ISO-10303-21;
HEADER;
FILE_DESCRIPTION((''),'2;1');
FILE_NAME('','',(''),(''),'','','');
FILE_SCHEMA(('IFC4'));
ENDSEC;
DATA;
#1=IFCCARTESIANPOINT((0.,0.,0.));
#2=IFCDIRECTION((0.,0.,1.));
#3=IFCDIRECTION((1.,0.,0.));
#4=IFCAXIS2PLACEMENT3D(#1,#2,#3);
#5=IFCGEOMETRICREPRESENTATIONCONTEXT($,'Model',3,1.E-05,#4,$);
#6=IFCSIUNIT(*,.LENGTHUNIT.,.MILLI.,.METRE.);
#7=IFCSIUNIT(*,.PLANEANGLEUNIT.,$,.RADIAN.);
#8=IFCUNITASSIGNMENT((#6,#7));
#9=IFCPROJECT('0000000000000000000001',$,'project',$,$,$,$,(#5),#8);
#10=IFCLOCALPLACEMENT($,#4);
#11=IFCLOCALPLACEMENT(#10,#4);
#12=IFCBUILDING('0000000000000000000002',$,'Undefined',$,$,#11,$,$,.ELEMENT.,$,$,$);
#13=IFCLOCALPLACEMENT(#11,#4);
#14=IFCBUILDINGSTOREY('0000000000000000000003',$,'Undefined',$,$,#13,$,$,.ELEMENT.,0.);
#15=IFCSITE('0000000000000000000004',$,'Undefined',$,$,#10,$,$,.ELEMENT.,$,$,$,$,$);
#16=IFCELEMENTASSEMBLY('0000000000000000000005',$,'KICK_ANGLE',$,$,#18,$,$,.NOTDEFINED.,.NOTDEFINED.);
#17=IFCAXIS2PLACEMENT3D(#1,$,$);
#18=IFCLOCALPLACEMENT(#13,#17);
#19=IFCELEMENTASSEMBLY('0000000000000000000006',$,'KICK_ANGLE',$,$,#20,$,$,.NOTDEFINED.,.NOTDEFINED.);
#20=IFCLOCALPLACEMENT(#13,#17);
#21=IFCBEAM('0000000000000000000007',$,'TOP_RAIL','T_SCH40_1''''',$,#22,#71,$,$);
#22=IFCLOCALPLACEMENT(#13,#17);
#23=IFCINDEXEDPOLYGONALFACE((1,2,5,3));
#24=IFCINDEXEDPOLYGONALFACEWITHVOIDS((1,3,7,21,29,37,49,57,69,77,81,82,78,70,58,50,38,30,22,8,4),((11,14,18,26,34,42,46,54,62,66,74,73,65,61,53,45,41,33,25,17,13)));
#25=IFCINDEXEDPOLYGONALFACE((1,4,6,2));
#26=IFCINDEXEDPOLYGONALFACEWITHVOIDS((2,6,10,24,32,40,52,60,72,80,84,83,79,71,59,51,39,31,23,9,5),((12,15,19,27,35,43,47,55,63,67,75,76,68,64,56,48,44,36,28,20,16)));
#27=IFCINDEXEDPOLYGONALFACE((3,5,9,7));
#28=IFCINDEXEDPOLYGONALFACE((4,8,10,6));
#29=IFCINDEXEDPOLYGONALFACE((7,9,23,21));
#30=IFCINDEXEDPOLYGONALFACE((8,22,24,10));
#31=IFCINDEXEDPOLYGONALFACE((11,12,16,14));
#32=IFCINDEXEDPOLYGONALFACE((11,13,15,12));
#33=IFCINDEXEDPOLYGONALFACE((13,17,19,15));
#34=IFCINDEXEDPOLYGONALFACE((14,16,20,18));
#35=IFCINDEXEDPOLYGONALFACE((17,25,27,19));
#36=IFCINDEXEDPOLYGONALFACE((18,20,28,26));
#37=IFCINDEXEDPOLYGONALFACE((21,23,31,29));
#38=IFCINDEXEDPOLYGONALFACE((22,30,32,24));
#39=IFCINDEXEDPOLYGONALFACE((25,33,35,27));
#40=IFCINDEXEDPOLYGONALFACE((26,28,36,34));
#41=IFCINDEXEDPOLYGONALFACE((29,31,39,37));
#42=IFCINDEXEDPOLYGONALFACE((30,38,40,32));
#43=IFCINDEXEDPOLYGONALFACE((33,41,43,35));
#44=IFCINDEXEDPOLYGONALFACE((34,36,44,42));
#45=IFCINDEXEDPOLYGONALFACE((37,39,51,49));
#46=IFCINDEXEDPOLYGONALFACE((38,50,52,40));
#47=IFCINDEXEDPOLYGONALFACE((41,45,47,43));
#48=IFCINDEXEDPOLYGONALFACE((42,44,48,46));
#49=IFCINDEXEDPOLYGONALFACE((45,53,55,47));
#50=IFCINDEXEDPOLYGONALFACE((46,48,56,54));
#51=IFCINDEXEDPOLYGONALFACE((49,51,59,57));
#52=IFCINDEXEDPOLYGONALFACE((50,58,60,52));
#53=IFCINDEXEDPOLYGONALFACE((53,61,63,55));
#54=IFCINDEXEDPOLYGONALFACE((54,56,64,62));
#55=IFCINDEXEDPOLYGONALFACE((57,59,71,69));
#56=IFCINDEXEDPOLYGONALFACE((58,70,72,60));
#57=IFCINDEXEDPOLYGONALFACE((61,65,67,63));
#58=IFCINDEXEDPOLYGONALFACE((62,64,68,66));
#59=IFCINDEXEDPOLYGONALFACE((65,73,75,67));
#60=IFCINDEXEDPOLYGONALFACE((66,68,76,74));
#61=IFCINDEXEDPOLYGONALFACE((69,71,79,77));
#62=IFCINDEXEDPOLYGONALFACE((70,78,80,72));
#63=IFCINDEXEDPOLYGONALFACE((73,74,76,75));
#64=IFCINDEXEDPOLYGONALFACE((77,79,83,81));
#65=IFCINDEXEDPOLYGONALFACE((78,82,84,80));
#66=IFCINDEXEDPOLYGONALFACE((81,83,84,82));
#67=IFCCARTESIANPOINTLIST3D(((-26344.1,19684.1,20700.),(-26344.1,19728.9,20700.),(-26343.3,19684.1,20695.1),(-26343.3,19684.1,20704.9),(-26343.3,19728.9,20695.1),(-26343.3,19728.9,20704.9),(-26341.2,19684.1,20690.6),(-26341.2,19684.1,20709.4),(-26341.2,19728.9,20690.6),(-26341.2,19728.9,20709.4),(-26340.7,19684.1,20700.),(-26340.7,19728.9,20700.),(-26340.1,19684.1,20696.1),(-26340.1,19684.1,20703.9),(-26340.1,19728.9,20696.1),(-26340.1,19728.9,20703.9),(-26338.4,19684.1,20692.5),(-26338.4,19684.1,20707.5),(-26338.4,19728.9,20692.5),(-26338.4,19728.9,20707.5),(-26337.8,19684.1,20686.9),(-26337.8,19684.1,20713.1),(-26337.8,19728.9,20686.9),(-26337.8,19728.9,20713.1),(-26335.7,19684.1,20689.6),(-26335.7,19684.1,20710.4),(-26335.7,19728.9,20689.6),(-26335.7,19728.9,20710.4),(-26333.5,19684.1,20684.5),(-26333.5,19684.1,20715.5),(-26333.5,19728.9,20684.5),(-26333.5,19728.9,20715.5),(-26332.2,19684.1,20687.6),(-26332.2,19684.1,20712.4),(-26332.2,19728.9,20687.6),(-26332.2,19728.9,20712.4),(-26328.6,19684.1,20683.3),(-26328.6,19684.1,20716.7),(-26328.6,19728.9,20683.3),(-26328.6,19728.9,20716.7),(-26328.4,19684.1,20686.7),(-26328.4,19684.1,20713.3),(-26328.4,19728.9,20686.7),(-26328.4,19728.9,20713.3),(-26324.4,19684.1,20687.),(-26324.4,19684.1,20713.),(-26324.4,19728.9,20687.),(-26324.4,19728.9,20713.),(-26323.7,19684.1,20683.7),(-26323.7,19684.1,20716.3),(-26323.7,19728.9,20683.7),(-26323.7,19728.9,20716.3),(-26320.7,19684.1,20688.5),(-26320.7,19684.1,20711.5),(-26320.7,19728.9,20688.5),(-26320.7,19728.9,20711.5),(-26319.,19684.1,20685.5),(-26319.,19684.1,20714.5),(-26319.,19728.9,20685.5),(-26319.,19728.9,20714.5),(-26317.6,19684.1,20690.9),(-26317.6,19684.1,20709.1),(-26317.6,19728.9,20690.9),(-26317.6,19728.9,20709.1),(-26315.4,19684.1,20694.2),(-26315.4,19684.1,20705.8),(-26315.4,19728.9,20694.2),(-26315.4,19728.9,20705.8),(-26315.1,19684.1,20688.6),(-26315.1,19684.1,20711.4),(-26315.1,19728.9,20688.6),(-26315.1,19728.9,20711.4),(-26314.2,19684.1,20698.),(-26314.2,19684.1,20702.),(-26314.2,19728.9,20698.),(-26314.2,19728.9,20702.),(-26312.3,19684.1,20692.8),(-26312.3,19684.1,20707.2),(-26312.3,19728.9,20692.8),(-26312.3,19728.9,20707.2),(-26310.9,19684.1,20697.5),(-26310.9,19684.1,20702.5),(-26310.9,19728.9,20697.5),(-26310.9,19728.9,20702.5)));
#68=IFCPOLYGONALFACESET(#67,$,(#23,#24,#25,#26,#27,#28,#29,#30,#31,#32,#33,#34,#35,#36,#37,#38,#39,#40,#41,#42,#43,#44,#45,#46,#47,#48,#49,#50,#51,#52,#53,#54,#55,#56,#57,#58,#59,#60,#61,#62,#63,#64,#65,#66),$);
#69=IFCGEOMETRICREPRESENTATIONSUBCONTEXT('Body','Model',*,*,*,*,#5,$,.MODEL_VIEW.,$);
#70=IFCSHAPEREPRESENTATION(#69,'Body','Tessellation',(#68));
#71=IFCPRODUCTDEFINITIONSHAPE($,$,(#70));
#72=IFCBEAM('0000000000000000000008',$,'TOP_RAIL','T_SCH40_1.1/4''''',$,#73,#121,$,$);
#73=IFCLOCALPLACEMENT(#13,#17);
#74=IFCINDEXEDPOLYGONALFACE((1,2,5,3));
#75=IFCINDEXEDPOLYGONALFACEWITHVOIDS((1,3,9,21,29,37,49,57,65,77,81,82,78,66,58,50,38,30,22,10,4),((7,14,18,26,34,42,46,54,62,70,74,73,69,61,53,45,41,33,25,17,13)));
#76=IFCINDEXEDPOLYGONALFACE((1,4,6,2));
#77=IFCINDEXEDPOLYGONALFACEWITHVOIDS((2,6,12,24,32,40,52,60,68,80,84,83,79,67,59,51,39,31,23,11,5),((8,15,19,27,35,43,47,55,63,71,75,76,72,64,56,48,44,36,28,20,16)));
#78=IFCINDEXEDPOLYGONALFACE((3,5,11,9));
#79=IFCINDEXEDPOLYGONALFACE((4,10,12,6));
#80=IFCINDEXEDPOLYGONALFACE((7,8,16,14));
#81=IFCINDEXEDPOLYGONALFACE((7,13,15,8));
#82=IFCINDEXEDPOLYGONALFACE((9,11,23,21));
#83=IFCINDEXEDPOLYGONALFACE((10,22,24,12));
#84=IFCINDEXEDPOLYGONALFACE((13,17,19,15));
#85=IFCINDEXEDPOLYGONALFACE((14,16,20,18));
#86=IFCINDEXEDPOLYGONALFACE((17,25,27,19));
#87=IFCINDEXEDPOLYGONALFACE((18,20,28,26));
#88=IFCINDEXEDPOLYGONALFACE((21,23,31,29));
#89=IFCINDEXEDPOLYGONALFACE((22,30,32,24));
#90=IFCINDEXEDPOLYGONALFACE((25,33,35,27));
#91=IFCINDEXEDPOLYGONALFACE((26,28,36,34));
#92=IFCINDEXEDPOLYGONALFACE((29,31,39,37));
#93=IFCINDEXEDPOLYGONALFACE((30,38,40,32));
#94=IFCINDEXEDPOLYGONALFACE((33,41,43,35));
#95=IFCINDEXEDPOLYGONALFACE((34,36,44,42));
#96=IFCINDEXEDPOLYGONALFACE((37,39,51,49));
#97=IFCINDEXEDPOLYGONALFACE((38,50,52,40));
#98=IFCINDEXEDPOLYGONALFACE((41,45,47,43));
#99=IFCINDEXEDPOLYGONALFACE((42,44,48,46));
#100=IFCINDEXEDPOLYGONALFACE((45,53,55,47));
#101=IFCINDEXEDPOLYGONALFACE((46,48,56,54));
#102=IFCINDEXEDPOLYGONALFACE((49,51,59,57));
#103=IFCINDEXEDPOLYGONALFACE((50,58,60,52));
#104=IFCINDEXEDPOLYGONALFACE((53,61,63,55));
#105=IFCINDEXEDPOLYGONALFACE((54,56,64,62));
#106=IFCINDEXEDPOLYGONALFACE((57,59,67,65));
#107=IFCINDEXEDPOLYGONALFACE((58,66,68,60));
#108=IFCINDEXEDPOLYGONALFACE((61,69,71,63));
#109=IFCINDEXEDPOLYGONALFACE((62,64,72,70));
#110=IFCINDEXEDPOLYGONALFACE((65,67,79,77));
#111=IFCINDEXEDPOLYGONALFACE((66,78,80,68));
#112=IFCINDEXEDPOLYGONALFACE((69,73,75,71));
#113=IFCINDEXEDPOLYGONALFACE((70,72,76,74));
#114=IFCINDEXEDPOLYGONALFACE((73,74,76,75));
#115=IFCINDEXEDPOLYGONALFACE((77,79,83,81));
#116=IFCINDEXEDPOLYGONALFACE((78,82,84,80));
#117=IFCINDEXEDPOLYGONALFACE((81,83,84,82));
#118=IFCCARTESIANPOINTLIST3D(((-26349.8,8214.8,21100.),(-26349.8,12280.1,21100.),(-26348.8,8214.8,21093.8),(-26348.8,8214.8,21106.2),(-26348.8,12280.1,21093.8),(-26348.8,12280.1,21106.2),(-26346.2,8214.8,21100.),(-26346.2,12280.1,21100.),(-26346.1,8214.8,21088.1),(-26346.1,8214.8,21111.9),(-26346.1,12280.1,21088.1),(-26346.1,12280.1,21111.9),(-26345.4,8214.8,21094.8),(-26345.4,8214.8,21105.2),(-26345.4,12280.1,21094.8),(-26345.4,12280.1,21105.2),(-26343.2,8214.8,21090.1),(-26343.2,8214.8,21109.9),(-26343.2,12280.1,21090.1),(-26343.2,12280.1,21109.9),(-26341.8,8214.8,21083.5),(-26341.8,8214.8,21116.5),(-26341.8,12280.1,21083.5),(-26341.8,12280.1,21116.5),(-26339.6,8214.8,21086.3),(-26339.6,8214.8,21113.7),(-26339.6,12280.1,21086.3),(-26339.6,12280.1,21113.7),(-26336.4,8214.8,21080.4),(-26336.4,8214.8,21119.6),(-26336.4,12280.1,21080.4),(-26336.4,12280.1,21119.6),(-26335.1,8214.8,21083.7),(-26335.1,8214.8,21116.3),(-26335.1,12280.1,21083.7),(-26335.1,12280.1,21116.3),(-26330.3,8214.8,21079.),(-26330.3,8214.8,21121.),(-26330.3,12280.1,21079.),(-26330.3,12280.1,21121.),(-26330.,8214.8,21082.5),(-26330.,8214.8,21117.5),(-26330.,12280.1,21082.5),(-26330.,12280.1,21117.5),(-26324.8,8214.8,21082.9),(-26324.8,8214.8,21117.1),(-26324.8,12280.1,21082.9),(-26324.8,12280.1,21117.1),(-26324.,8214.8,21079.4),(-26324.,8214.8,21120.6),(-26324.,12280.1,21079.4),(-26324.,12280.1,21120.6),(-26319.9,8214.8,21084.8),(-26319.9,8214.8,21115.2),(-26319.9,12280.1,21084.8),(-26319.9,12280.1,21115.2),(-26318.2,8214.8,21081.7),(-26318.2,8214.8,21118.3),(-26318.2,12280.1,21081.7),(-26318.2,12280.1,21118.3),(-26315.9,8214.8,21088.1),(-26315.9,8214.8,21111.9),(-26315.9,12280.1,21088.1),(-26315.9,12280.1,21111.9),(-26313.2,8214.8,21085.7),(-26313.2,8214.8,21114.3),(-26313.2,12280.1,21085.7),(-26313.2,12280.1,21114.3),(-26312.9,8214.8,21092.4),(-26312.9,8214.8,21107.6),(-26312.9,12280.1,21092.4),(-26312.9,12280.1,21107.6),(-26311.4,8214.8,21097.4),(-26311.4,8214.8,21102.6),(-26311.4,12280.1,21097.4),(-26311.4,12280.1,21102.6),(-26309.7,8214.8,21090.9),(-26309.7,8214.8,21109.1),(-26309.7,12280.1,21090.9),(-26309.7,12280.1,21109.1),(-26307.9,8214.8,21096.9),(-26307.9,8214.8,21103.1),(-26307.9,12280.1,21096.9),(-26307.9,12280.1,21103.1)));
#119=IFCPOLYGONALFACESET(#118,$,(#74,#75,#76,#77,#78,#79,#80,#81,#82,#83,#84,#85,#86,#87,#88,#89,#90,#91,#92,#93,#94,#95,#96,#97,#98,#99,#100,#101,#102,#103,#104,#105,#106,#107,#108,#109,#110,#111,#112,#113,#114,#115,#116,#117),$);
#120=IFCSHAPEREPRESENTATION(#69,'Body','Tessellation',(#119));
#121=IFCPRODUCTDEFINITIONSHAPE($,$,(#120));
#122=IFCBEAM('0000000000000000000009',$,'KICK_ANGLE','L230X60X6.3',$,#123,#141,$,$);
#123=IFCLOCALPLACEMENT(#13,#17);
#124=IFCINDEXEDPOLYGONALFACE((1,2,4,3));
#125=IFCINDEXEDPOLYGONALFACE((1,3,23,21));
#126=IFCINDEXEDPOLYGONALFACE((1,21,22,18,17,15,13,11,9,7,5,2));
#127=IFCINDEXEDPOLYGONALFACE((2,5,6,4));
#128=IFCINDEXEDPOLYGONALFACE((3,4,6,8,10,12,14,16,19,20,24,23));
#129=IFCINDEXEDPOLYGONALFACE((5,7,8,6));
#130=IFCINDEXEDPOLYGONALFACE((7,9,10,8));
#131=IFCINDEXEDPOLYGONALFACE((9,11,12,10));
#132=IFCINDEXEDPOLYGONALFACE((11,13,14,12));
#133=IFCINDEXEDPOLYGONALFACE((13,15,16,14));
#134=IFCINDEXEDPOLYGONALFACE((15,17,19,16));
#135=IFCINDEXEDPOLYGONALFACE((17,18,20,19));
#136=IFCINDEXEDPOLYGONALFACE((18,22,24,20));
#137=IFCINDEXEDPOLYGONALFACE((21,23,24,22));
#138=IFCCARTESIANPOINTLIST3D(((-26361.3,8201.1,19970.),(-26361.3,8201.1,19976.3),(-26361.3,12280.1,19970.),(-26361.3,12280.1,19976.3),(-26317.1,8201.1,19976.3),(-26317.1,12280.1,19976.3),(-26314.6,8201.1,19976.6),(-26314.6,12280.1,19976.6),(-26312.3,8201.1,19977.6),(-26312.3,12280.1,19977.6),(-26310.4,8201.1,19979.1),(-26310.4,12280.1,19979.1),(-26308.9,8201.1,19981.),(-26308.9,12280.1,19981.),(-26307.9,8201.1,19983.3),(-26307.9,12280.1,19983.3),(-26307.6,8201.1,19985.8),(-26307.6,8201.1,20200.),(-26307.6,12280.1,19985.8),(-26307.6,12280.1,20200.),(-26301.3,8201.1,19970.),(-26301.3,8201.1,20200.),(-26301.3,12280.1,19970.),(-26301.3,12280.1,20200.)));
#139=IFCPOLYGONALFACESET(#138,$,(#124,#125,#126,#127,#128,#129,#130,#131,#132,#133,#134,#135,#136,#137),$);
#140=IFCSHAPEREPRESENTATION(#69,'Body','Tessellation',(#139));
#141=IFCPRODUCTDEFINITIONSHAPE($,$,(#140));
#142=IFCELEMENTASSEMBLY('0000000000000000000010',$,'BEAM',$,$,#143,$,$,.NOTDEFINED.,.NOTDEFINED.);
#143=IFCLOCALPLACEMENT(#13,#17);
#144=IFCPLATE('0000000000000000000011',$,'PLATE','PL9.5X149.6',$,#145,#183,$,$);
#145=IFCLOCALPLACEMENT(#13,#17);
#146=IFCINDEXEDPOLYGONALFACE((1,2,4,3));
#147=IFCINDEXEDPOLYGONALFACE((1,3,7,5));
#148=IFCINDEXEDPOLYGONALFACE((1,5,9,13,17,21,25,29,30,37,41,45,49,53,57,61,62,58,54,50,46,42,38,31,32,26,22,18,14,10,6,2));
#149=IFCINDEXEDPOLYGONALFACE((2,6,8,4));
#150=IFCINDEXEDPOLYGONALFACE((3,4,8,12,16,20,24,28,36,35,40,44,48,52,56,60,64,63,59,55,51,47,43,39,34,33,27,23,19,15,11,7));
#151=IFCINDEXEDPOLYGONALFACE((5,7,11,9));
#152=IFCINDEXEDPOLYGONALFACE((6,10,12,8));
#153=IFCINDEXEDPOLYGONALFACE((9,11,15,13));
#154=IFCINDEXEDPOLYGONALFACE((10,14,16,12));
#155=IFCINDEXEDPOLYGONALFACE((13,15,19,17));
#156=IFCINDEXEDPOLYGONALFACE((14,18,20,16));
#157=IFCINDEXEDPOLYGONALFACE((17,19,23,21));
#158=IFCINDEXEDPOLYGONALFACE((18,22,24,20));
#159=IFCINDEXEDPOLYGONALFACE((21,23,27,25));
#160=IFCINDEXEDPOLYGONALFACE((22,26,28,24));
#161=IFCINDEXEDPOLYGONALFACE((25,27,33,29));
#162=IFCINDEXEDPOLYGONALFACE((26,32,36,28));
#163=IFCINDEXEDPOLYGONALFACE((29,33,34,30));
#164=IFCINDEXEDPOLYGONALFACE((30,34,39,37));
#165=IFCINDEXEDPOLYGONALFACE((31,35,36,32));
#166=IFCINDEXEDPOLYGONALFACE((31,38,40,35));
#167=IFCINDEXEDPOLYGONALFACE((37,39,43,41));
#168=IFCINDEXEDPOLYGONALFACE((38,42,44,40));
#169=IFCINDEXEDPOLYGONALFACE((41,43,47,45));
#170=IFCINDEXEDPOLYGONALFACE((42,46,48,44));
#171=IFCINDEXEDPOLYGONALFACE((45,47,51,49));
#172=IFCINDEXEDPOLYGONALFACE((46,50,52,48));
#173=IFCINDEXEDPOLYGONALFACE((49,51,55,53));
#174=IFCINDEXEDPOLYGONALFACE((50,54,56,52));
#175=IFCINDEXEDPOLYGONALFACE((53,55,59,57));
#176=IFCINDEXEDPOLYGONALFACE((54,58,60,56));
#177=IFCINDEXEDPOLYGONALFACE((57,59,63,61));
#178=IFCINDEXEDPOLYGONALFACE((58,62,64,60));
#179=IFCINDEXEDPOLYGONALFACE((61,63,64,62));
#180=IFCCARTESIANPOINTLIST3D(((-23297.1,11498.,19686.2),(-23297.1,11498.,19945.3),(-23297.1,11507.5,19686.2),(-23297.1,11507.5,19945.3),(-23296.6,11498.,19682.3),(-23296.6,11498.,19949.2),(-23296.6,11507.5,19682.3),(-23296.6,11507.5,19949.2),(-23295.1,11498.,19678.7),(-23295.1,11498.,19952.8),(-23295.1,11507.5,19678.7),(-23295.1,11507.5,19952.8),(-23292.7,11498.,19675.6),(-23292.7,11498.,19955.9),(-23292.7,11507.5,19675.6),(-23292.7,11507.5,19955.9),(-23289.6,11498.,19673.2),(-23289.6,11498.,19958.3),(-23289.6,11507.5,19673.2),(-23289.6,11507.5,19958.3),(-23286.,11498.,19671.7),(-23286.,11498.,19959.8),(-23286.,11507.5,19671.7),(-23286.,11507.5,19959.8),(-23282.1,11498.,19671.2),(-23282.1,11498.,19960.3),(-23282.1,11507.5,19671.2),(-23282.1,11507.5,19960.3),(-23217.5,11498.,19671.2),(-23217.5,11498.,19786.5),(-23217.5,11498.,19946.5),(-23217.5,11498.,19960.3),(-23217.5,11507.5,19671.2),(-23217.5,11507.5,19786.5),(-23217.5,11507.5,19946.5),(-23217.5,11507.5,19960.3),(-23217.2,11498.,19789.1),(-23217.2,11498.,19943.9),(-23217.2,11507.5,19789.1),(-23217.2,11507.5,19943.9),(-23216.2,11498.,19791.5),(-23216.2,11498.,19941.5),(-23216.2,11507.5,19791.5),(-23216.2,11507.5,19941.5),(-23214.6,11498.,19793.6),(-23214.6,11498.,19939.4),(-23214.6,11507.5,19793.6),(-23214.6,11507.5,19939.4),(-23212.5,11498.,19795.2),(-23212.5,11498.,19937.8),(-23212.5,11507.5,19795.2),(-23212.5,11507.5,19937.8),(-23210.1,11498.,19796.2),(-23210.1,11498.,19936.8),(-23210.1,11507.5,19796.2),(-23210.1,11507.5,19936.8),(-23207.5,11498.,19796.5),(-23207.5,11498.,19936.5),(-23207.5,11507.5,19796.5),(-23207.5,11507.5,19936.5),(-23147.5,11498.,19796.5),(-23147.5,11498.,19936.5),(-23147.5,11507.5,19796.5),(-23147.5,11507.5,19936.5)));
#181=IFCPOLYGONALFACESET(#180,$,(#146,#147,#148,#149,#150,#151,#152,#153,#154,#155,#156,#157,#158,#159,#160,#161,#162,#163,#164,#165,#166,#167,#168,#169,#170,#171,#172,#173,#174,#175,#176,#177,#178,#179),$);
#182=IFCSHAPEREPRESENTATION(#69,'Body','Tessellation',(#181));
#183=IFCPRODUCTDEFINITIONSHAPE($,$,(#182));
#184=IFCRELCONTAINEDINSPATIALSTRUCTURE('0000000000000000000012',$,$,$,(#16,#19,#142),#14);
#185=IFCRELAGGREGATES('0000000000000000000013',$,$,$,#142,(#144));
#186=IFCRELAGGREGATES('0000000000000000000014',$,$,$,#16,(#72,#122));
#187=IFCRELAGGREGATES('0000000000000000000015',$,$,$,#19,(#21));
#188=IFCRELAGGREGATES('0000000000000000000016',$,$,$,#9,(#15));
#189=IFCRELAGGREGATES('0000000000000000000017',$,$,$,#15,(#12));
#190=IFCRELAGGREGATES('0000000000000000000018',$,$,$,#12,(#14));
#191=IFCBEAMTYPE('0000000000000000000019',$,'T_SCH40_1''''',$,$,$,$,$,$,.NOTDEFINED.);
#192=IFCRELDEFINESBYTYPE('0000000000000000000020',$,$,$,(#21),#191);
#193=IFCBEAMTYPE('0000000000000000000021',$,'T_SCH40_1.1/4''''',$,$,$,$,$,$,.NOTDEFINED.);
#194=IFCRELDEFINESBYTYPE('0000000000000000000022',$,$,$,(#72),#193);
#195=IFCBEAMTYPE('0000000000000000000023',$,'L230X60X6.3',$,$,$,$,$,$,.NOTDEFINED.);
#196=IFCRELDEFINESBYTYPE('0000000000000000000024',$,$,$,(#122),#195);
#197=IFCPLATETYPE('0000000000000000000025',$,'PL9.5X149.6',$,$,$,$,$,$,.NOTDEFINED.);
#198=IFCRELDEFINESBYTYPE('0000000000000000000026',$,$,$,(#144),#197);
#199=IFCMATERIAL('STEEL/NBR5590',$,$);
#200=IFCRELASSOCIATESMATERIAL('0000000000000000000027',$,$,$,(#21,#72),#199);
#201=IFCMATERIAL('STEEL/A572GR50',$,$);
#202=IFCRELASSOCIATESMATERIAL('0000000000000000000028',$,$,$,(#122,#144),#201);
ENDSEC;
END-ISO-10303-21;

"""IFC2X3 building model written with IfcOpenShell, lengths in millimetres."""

from ifc_helpers import new_model, si_unit, frame, frame_2d, origin_with_axes, origin_2d_with_axis, place, context, subcontext, project, spatial, polyline, circle_curve, parameter, trimmed, segment, composite_curve, hollow_circle, l_section, outline, extrude, clip, halfspace, material, type_object, element, aggregate, save


model = new_model("IFC2X3")

# Units and contexts
model_context = context("Model", 3, precision=1e-05, world=origin_with_axes())
body_context = subcontext(model_context, "Body", "Model", "MODEL_VIEW")
ifc_project = project(units=[si_unit("LENGTHUNIT", "METRE", prefix="MILLI"), si_unit("PLANEANGLEUNIT", "RADIAN")], contexts=[model_context])

# Site, building, storey
site_placement = place(None, origin_with_axes())
site = spatial("IfcSite", under=ifc_project, at=site_placement, Name="Undefined", CompositionType="ELEMENT")
building_placement = place(site_placement, origin_with_axes())
building = spatial("IfcBuilding", under=site, at=building_placement, Name="Undefined", CompositionType="ELEMENT")
storey_placement = place(building_placement, origin_with_axes())
storey = spatial("IfcBuildingStorey", under=building, at=storey_placement, Name="Undefined", CompositionType="ELEMENT", Elevation=0.0)

# Element assembly
assembly_1_placement = place(storey_placement, origin_with_axes())
assembly_1 = element("IfcElementAssembly", 1, at=assembly_1_placement, inside=storey, Name="KICK_ANGLE", AssemblyPlace="NOTDEFINED", PredefinedType="NOTDEFINED")
ifc_material_1 = material(Name="STEEL/NBR5590")

# Element assembly
assembly_2_placement = place(storey_placement, origin_with_axes())
assembly_2 = element("IfcElementAssembly", 2, at=assembly_2_placement, inside=storey, Name="KICK_ANGLE", AssemblyPlace="NOTDEFINED", PredefinedType="NOTDEFINED")

# Shared definitions
ifc_material_2 = material(Name="STEEL/A572GR50")

# Beams
beam_type_1 = type_object("IfcBeamType", Name="T_SCH40_1''", PredefinedType="NOTDEFINED")
beam_1_placement = place(assembly_2_placement, frame((-26327.4, 19728.9, 20700.0), z_axis=(0.0, 0.0, 1.0), x_axis=(0.0, -1.0, 0.0)))
beam_1 = element("IfcBeam", 3, at=beam_1_placement, type_object=beam_type_1, material=ifc_material_1, Name="TOP_RAIL", Description="T_SCH40_1''", context=body_context, shape_type="Clipping", body=[
    clip(extrude(hollow_circle(Radius=16.7, WallThickness=3.4, at=origin_2d_with_axis()), frame((44.8, 0.0, 0.0), z_axis=(-1.0, 0.0, 0.0), x_axis=(0.0, -1.0, 0.0)), (0.0, 0.0, 1.0), 44.8), halfspace(frame((44.8, 0.0, 0.0), z_axis=(1.0, 0.0, 0.0), x_axis=(0.0, -1.0, 0.0)), False)),
])
beam_type_2 = type_object("IfcBeamType", Name="T_SCH40_1.1/4''", PredefinedType="NOTDEFINED")
beam_2_placement = place(assembly_1_placement, frame((-26328.7, 12280.1, 21100.0), z_axis=(0.0, 0.0, 1.0), x_axis=(0.0, -1.0, 0.0)))
beam_2 = element("IfcBeam", 4, at=beam_2_placement, type_object=beam_type_2, material=ifc_material_1, Name="TOP_RAIL", Description="T_SCH40_1.1/4''", context=body_context, shape_type="Clipping", body=[
    clip(extrude(hollow_circle(Radius=21.1, WallThickness=3.6, at=origin_2d_with_axis()), frame((4079.0, 0.0, 0.0), z_axis=(-1.0, 0.0, 0.0), x_axis=(0.0, -1.0, 0.0)), (0.0, 0.0, 1.0), 4079.0), halfspace(frame((4065.3, 0.0, 0.0), z_axis=(1.0, 0.0, 0.0), x_axis=(0.0, -1.0, 0.0)), False)),
])
beam_type_3 = type_object("IfcBeamType", Name="L230X60X6.3", PredefinedType="NOTDEFINED")
beam_3_placement = place(assembly_1_placement, frame((-26331.3, 12280.1, 20085.0), z_axis=(0.0, 0.0, 1.0), x_axis=(0.0, -1.0, 0.0)))
beam_3 = element("IfcBeam", 5, at=beam_3_placement, type_object=beam_type_3, material=ifc_material_2, Name="KICK_ANGLE", Description="L230X60X6.3", context=body_context, shape_type="Clipping", body=[
    clip(extrude(l_section(Depth=230.0, Width=60.0, Thickness=6.3, FilletRadius=9.4, at=origin_2d_with_axis()), frame((4079.0, 0.0, 0.0), z_axis=(-1.0, 0.0, 0.0), x_axis=(0.0, -1.0, 0.0)), (0.0, 0.0, 1.0), 4079.0), halfspace(frame((0.0, 0.0, 0.0), z_axis=(1.0, 0.0, 0.0), x_axis=(0.0, -1.0, 0.0)), True)),
])

# Element assembly, plate
assembly_3_placement = place(storey_placement, origin_with_axes())
assembly_3 = element("IfcElementAssembly", 6, at=assembly_3_placement, inside=storey, Name="BEAM", AssemblyPlace="NOTDEFINED", PredefinedType="NOTDEFINED")
plate_type_1 = type_object("IfcPlateType", Name="PL9.5X149.6", PredefinedType="NOTDEFINED")
plate_1_placement = place(assembly_3_placement, frame((-23297.1, 11502.7, 19960.3), z_axis=(0.0, -1.0, 0.0), x_axis=(0.0, 0.0, -1.0)))
plate_1 = element("IfcPlate", 7, at=plate_1_placement, type_object=plate_type_1, material=ifc_material_2, Name="PLATE", Description="PL9.5X149.6", context=body_context, shape_type="SweptSolid", body=[
    extrude(outline(composite_curve([segment(trimmed(circle_curve(frame_2d((15.0, 15.0), x_axis=(-1.0, 0.0)), 15.0), [parameter(0.0)], [parameter(1.570796)], True, "PARAMETER"), True, "CONTINUOUS"), segment(polyline([(15.0, 0.0), (274.1, 0.0)]), True, "CONTINUOUS"), segment(trimmed(circle_curve(frame_2d((274.1, 15.0), x_axis=(0.0, -1.0)), 15.0), [parameter(0.0)], [parameter(1.570796)], True, "PARAMETER"), True, "CONTINUOUS"), segment(polyline([(289.1, 15.0), (289.1, 79.6), (173.8, 79.6)]), True, "CONTINUOUS"), segment(trimmed(circle_curve(frame_2d((173.8, 89.6), x_axis=(0.0, -1.0)), 10.0), [parameter(0.0)], [parameter(4.712389)], False, "PARAMETER"), True, "CONTINUOUS"), segment(polyline([(163.8, 89.6), (163.8, 149.6), (23.8, 149.6), (23.8, 89.6)]), True, "CONTINUOUS"), segment(trimmed(circle_curve(frame_2d((13.8, 89.6), x_axis=(1.0, 0.0)), 10.0), [parameter(0.0)], [parameter(4.712389)], False, "PARAMETER"), True, "CONTINUOUS"), segment(polyline([(13.8, 79.6), (0.0, 79.6), (0.0, 15.0)]), True, "CONTINUOUS")], self_intersect=True)), frame((0.0, 0.0, -4.8), z_axis=(0.0, 0.0, 1.0), x_axis=(1.0, 0.0, 0.0)), (0.0, 0.0, 1.0), 9.5),
])

aggregate(assembly_3, [plate_1])

aggregate(assembly_1, [beam_2, beam_3])
aggregate(assembly_2, [beam_1])

save(model, "model.ifc")
